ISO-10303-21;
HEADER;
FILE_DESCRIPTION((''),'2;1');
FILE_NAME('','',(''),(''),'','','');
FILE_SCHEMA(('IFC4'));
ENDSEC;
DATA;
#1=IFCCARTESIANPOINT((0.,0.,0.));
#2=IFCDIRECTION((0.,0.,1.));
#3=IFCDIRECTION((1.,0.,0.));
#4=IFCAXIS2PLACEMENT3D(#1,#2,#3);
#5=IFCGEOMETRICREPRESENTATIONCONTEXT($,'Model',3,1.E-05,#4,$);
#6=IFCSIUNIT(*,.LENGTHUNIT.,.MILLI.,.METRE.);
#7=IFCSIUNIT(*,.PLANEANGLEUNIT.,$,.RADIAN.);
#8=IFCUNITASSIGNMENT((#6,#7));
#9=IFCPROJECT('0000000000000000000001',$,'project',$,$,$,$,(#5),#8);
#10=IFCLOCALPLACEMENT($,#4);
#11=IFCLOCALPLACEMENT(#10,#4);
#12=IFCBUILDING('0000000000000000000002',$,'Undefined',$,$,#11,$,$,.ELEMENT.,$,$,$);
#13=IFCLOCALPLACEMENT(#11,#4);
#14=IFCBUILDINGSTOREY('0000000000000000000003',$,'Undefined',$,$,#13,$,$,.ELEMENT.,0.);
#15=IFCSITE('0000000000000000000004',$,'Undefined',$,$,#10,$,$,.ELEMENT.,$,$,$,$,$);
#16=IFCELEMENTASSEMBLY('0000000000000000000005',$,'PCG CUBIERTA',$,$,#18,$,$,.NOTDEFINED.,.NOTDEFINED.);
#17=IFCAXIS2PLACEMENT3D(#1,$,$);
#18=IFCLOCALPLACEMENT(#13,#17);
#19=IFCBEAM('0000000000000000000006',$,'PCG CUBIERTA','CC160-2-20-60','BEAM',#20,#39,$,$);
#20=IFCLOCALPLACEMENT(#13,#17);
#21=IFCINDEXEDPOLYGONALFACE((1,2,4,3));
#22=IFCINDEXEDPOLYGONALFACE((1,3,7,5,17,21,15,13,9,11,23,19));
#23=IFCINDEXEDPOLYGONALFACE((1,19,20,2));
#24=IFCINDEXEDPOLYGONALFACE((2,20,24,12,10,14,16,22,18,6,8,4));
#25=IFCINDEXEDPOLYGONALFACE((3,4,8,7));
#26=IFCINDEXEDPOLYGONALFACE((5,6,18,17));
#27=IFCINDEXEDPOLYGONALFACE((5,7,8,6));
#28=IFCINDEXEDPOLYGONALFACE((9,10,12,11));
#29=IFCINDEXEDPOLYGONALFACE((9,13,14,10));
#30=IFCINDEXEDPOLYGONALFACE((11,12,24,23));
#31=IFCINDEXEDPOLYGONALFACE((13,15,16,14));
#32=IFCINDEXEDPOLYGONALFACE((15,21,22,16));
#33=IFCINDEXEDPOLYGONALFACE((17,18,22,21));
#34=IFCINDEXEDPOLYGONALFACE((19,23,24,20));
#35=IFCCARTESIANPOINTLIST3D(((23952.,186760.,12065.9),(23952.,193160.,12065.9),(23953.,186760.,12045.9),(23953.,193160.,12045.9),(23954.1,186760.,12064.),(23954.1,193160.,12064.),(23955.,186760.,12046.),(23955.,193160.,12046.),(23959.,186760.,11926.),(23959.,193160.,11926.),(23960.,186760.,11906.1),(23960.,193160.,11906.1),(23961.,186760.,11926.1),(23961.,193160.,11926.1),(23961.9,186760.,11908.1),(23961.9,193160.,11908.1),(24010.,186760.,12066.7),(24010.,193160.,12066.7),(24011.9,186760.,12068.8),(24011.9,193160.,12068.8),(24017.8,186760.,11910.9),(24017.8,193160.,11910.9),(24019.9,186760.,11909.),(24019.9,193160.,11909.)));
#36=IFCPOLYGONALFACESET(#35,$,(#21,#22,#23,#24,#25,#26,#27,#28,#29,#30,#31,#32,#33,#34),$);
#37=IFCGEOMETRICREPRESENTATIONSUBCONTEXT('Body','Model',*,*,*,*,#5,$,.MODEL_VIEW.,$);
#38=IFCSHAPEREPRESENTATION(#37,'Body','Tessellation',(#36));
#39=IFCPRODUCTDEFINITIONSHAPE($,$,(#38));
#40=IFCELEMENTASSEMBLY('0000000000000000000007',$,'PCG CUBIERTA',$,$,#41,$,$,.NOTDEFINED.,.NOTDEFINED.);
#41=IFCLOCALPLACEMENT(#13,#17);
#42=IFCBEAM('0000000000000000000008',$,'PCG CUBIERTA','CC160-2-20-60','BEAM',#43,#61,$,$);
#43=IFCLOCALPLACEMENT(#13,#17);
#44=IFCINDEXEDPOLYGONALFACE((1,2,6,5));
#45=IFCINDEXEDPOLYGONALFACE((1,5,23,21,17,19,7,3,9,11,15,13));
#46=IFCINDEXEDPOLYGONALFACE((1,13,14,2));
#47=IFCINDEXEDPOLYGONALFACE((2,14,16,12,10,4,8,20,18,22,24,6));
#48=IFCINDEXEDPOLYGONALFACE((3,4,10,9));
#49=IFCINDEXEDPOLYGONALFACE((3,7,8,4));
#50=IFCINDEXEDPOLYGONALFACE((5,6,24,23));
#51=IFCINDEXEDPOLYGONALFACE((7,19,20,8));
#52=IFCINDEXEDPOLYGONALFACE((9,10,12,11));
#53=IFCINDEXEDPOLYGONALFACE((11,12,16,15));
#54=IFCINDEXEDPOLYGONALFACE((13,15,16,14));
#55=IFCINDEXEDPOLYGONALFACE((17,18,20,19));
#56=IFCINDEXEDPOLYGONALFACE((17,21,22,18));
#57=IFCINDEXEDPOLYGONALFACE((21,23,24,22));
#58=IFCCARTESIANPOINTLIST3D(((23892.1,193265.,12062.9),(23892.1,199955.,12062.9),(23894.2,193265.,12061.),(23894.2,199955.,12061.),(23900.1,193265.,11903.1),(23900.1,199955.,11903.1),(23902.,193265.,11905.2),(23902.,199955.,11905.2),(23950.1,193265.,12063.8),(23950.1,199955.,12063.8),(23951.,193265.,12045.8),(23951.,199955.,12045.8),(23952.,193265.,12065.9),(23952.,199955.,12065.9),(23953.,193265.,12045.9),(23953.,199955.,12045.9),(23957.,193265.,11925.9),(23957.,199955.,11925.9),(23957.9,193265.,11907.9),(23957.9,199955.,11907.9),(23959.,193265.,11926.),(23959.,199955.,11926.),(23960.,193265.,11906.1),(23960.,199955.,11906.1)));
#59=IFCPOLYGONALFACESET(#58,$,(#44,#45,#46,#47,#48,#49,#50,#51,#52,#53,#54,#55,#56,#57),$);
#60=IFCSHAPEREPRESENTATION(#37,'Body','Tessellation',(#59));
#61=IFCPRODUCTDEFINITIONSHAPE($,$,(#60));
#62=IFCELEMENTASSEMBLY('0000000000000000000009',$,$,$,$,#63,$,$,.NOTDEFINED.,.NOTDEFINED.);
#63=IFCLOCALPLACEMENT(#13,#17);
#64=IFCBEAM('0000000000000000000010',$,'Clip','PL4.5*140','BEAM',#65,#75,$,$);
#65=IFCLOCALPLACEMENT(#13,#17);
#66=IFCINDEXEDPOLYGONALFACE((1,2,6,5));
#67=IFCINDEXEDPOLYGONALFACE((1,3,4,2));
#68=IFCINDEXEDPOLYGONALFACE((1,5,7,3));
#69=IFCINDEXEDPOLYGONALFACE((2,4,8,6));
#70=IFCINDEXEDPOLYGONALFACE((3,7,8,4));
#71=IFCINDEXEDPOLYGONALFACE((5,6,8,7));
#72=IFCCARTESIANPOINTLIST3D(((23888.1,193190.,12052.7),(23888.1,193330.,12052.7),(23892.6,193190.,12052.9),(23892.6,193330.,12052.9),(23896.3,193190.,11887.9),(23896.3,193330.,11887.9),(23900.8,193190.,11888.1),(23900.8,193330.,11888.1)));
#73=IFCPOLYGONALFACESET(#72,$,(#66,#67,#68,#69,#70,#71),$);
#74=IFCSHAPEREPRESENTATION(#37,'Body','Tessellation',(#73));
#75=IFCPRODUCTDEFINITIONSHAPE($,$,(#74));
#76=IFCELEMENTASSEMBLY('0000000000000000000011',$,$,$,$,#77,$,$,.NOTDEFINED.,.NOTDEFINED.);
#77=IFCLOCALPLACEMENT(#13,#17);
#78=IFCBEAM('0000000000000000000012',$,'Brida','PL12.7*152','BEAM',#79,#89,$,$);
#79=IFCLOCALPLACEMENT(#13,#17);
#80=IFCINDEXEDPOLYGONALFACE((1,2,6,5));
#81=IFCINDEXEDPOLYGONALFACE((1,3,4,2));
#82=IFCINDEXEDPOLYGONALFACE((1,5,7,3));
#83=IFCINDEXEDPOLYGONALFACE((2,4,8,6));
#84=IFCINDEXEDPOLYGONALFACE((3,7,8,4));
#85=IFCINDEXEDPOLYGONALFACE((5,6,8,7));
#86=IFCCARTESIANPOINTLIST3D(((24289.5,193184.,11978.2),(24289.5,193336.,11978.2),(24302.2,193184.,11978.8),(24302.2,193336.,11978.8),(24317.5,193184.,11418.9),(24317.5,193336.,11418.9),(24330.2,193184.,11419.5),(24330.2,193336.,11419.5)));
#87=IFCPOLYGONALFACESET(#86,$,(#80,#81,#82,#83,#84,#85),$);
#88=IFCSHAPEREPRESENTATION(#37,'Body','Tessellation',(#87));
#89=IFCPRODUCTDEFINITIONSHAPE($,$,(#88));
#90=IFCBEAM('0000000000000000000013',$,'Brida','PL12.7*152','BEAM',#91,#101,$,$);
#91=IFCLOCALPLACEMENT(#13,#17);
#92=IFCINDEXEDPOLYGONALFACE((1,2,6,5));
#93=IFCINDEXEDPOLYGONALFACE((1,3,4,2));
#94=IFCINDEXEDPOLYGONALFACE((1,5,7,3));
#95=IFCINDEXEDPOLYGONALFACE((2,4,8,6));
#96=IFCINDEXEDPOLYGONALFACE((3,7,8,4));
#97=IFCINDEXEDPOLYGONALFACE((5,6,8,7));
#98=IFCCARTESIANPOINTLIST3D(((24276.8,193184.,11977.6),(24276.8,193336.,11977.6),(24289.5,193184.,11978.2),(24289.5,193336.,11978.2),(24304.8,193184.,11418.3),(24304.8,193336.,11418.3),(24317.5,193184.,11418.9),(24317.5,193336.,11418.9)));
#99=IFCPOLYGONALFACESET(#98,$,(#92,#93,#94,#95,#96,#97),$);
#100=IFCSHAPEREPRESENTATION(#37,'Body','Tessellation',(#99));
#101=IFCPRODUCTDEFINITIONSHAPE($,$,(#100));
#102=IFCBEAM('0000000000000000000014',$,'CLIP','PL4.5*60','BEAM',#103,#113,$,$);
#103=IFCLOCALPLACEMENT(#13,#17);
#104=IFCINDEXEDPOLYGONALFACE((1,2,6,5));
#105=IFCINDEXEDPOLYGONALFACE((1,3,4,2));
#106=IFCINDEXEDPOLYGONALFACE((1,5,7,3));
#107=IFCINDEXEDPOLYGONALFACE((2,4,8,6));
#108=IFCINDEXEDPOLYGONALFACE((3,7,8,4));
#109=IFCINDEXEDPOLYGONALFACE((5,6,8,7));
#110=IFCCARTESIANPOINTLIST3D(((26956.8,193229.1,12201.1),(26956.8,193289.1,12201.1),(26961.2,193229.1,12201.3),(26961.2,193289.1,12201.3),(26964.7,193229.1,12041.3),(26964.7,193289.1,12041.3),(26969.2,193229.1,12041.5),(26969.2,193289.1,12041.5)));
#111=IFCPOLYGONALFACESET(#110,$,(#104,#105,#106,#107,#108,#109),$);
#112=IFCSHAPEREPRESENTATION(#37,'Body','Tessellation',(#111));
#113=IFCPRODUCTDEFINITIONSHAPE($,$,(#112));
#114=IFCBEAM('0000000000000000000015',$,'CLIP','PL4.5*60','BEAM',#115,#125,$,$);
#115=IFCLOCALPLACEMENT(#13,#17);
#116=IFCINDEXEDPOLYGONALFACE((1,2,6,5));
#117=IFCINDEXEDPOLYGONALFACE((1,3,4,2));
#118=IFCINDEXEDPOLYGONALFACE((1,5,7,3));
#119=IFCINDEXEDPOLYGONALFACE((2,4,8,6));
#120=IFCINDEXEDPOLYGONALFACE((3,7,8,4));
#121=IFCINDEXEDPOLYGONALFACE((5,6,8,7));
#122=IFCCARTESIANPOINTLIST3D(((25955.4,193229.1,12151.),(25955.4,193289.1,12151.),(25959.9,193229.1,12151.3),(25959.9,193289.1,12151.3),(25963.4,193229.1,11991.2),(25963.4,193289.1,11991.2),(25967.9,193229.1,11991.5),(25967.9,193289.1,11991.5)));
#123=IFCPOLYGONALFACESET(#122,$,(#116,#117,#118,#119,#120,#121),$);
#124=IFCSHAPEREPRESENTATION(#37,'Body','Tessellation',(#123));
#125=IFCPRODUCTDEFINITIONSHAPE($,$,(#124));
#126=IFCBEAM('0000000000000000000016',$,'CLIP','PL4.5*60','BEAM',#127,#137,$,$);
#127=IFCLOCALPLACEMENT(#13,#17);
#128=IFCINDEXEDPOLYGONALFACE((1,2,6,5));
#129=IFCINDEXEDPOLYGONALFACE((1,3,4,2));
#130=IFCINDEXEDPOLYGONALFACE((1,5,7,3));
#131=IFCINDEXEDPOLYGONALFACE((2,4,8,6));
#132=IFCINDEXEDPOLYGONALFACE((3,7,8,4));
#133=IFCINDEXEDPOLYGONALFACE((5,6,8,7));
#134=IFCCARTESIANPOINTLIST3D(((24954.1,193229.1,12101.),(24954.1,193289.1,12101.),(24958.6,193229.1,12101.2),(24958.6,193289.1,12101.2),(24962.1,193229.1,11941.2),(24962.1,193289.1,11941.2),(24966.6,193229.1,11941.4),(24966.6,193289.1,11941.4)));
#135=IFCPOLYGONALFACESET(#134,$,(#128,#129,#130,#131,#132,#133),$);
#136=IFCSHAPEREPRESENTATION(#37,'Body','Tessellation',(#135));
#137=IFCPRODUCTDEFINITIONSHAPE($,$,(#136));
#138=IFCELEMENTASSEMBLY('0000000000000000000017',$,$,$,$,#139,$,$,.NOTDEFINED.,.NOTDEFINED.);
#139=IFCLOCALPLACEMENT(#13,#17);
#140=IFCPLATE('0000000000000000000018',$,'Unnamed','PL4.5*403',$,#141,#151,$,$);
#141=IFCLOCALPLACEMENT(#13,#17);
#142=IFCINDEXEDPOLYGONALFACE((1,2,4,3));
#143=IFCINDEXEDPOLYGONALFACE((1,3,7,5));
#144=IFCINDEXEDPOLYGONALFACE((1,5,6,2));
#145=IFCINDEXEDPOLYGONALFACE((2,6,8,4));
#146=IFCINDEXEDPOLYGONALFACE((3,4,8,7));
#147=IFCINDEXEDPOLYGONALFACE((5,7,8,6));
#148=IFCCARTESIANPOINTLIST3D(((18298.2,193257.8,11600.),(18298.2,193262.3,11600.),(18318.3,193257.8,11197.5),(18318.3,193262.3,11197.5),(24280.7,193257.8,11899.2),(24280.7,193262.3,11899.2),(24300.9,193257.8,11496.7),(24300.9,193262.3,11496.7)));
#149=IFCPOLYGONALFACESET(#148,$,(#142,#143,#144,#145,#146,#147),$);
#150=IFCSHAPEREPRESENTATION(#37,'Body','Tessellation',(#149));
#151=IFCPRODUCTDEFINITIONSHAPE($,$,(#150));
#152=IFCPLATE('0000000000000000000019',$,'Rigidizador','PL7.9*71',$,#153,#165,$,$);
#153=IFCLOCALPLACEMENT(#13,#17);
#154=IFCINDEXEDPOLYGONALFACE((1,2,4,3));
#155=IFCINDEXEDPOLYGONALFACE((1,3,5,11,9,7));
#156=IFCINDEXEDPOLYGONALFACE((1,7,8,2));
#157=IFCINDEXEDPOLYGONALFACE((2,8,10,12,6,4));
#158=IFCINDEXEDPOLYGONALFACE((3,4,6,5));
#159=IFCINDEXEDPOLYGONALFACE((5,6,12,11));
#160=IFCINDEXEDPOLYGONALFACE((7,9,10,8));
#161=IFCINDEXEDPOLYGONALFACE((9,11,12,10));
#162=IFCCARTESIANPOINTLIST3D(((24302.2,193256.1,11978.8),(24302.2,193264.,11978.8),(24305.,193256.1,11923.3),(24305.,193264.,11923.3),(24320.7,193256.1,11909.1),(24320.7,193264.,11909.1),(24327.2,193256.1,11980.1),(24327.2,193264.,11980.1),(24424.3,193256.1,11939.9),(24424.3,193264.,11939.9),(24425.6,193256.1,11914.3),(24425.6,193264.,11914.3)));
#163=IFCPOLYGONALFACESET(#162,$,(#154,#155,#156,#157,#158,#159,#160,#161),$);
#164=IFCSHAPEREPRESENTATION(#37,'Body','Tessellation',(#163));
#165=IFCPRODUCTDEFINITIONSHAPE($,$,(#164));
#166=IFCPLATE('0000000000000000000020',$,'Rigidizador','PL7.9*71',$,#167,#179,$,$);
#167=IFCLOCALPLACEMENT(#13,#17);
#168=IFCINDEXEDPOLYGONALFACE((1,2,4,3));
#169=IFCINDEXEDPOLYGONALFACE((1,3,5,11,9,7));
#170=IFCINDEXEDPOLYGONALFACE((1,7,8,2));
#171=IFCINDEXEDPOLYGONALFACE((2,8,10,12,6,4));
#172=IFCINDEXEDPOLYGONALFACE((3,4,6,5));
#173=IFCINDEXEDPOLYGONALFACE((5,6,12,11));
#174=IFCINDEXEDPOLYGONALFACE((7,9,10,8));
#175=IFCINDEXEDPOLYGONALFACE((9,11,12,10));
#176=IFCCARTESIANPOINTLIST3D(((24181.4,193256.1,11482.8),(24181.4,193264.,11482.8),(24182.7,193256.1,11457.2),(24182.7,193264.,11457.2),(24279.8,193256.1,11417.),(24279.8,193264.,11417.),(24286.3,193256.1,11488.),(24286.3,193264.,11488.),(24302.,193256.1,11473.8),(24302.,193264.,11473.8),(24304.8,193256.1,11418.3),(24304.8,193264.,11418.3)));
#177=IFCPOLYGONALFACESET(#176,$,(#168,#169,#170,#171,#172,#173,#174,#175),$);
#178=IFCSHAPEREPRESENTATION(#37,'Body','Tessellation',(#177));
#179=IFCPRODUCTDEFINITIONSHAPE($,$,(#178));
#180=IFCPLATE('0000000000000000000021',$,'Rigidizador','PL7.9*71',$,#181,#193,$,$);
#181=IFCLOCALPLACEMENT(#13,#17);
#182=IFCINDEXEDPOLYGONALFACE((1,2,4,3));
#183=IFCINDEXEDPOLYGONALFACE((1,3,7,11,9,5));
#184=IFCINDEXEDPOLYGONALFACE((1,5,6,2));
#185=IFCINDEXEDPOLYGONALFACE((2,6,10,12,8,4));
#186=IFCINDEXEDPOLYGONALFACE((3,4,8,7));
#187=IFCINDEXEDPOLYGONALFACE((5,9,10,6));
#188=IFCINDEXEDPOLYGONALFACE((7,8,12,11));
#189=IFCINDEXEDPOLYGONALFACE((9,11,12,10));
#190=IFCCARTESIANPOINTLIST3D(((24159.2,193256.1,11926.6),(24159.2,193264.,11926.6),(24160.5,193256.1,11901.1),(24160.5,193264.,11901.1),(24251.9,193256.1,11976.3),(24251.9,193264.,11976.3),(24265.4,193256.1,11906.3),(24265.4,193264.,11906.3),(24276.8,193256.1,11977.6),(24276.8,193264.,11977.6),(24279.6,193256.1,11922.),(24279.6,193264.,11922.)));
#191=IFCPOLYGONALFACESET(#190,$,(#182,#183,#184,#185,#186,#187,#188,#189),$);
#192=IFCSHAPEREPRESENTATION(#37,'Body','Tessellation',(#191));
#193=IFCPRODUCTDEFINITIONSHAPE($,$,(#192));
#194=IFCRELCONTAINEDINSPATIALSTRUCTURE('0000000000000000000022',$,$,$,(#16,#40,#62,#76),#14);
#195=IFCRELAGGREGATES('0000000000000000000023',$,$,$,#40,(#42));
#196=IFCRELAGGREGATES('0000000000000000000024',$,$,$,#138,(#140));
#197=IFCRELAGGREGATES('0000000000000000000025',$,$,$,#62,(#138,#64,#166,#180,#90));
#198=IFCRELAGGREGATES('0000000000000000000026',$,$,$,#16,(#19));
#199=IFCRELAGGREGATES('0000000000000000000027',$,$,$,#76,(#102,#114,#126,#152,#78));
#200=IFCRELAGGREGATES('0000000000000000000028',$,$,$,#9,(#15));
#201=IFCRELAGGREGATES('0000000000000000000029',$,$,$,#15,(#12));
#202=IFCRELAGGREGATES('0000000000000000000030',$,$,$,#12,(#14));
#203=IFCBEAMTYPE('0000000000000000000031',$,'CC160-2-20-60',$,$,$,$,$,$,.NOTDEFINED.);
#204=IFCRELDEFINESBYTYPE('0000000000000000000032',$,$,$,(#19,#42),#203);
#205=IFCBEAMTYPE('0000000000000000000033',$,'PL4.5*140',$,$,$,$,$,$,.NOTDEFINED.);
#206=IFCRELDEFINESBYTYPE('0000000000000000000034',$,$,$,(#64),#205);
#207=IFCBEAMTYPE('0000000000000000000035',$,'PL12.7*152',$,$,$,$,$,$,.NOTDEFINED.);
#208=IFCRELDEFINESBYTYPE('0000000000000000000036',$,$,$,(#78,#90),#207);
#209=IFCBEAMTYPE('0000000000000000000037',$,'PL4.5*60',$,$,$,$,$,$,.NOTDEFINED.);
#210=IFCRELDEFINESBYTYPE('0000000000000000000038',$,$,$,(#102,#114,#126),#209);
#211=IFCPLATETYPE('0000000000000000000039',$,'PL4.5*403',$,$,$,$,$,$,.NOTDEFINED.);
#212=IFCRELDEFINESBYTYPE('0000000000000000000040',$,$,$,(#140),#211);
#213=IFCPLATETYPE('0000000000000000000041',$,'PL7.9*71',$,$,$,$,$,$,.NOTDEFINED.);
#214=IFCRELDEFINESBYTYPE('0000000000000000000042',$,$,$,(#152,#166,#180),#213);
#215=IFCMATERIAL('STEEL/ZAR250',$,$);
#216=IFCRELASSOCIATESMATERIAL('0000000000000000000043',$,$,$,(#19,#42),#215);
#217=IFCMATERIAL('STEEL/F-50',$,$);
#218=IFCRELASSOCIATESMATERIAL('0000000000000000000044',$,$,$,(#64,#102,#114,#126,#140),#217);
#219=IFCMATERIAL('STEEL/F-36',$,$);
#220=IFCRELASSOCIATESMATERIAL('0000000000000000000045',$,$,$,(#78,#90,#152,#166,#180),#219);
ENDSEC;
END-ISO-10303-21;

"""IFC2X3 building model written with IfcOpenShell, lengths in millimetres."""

from ifc_helpers import new_model, si_unit, frame, origin_with_axes, origin_2d_with_axis, place, context, subcontext, project, spatial, polyline, rectangle, c_section, outline, extrude, material, type_object, element, aggregate, save


model = new_model("IFC2X3")

# Units and contexts
model_context = context("Model", 3, precision=1e-05, world=origin_with_axes())
body_context = subcontext(model_context, "Body", "Model", "MODEL_VIEW")
ifc_project = project(units=[si_unit("LENGTHUNIT", "METRE", prefix="MILLI"), si_unit("PLANEANGLEUNIT", "RADIAN")], contexts=[model_context])

# Site, building, storey
site_placement = place(None, origin_with_axes())
site = spatial("IfcSite", under=ifc_project, at=site_placement, Name="Undefined", CompositionType="ELEMENT")
building_placement = place(site_placement, origin_with_axes())
building = spatial("IfcBuilding", under=site, at=building_placement, Name="Undefined", CompositionType="ELEMENT")
storey_placement = place(building_placement, origin_with_axes())
storey = spatial("IfcBuildingStorey", under=building, at=storey_placement, Name="Undefined", CompositionType="ELEMENT", Elevation=0.0)

# Element assemblies, beams
assembly_1_placement = place(storey_placement, origin_with_axes())
assembly_1 = element("IfcElementAssembly", 1, at=assembly_1_placement, inside=storey, Name="PCG CUBIERTA", AssemblyPlace="NOTDEFINED", PredefinedType="NOTDEFINED")
ifc_material_1 = material(Name="STEEL/ZAR250")
beam_type_1 = type_object("IfcBeamType", Name="CC160-2-20-60", PredefinedType="NOTDEFINED")
beam_1_placement = place(assembly_1_placement, frame((23986.0, 193160.0, 11987.4), z_axis=(-0.049943, 0.0, 0.998752), x_axis=(0.0, -1.0, 0.0)))
beam_1 = element("IfcBeam", 2, at=beam_1_placement, type_object=beam_type_1, material=ifc_material_1, Name="PCG CUBIERTA", Description="CC160-2-20-60", ObjectType="BEAM", context=body_context, shape_type="SweptSolid", body=[
    extrude(c_section(Depth=160.0, Width=60.0, WallThickness=2.0, Girth=20.0, at=origin_2d_with_axis()), frame((6400.0, 0.0, 0.0), z_axis=(-1.0, 0.0, 0.0), x_axis=(0.0, -1.0, 0.0)), (0.0, 0.0, 1.0), 6400.0),
])
assembly_2_placement = place(storey_placement, origin_with_axes())
assembly_2 = element("IfcElementAssembly", 3, at=assembly_2_placement, inside=storey, Name="PCG CUBIERTA", AssemblyPlace="NOTDEFINED", PredefinedType="NOTDEFINED")
beam_2_placement = place(assembly_2_placement, frame((23926.0, 193265.0, 11984.5), z_axis=(-0.049943, 0.0, 0.998752), x_axis=(0.0, 1.0, 0.0)))
beam_2 = element("IfcBeam", 4, at=beam_2_placement, type_object=beam_type_1, material=ifc_material_1, Name="PCG CUBIERTA", Description="CC160-2-20-60", ObjectType="BEAM", context=body_context, shape_type="SweptSolid", body=[
    extrude(c_section(Depth=160.0, Width=60.0, WallThickness=2.0, Girth=20.0, at=origin_2d_with_axis()), frame((6690.0, 0.0, 0.0), z_axis=(-1.0, 0.0, 0.0), x_axis=(0.0, -1.0, 0.0)), (0.0, 0.0, 1.0), 6690.0),
])
aggregate(assembly_2, [beam_2])
assembly_3_placement = place(storey_placement, origin_with_axes())
assembly_3 = element("IfcElementAssembly", 5, at=assembly_3_placement, inside=storey, AssemblyPlace="NOTDEFINED", PredefinedType="NOTDEFINED")
ifc_material_2 = material(Name="STEEL/F-50")
beam_type_2 = type_object("IfcBeamType", Name="PL4.5*140", PredefinedType="NOTDEFINED")
beam_3_placement = place(assembly_3_placement, frame((23890.3, 193260.0, 12052.8), z_axis=(0.0, -1.0, 0.0), x_axis=(0.049943, 0.0, -0.998752)))
beam_3 = element("IfcBeam", 6, at=beam_3_placement, type_object=beam_type_2, material=ifc_material_2, Name="Clip", Description="PL4.5*140", ObjectType="BEAM", context=body_context, shape_type="SweptSolid", body=[
    extrude(rectangle(XDim=4.5, YDim=140.0, at=origin_2d_with_axis()), frame((165.0, 0.0, 0.0), z_axis=(-1.0, 0.0, 0.0), x_axis=(0.0, -1.0, 0.0)), (0.0, 0.0, 1.0), 165.0),
])
assembly_4_placement = place(storey_placement, origin_with_axes())
assembly_4 = element("IfcElementAssembly", 7, at=assembly_4_placement, inside=storey, AssemblyPlace="NOTDEFINED", PredefinedType="NOTDEFINED")
ifc_material_3 = material(Name="STEEL/F-36")
beam_type_3 = type_object("IfcBeamType", Name="PL12.7*152", PredefinedType="NOTDEFINED")
beam_4_placement = place(assembly_4_placement, frame((24295.8, 193260.0, 11978.5), z_axis=(0.0, 1.0, 0.0), x_axis=(0.049943, 0.0, -0.998752)))
beam_4 = element("IfcBeam", 8, at=beam_4_placement, type_object=beam_type_3, material=ifc_material_3, Name="Brida", Description="PL12.7*152", ObjectType="BEAM", context=body_context, shape_type="SweptSolid", body=[
    extrude(rectangle(XDim=12.7, YDim=152.0, at=origin_2d_with_axis()), frame((560.0, 0.0, 0.0), z_axis=(-1.0, 0.0, 0.0), x_axis=(0.0, -1.0, 0.0)), (0.0, 0.0, 1.0), 560.0),
])

# Beams
beam_5_placement = place(assembly_3_placement, frame((24283.2, 193260.0, 11977.9), z_axis=(0.0, 1.0, 0.0), x_axis=(0.049943, 0.0, -0.998752)))
beam_5 = element("IfcBeam", 9, at=beam_5_placement, type_object=beam_type_3, material=ifc_material_3, Name="Brida", Description="PL12.7*152", ObjectType="BEAM", context=body_context, shape_type="SweptSolid", body=[
    extrude(rectangle(XDim=12.7, YDim=152.0, at=origin_2d_with_axis()), frame((560.0, 0.0, 0.0), z_axis=(-1.0, 0.0, 0.0), x_axis=(0.0, -1.0, 0.0)), (0.0, 0.0, 1.0), 560.0),
])
beam_type_4 = type_object("IfcBeamType", Name="PL4.5*60", PredefinedType="NOTDEFINED")
beam_6_placement = place(assembly_4_placement, frame((26959.0, 193259.1, 12201.2), z_axis=(0.0, 1.0, 0.0), x_axis=(0.049943, 0.0, -0.998752)))
beam_6 = element("IfcBeam", 10, at=beam_6_placement, type_object=beam_type_4, material=ifc_material_2, Name="CLIP", Description="PL4.5*60", ObjectType="BEAM", context=body_context, shape_type="SweptSolid", body=[
    extrude(rectangle(XDim=4.5, YDim=60.0, at=origin_2d_with_axis()), frame((160.0, 0.0, 0.0), z_axis=(-1.0, 0.0, 0.0), x_axis=(0.0, -1.0, 0.0)), (0.0, 0.0, 1.0), 160.0),
])
beam_7_placement = place(assembly_4_placement, frame((25957.7, 193259.1, 12151.1), z_axis=(0.0, 1.0, 0.0), x_axis=(0.049943, 0.0, -0.998752)))
beam_7 = element("IfcBeam", 11, at=beam_7_placement, type_object=beam_type_4, material=ifc_material_2, Name="CLIP", Description="PL4.5*60", ObjectType="BEAM", context=body_context, shape_type="SweptSolid", body=[
    extrude(rectangle(XDim=4.5, YDim=60.0, at=origin_2d_with_axis()), frame((160.0, 0.0, 0.0), z_axis=(-1.0, 0.0, 0.0), x_axis=(0.0, -1.0, 0.0)), (0.0, 0.0, 1.0), 160.0),
])
beam_8_placement = place(assembly_4_placement, frame((24956.3, 193259.1, 12101.1), z_axis=(0.0, 1.0, 0.0), x_axis=(0.049943, 0.0, -0.998752)))
beam_8 = element("IfcBeam", 12, at=beam_8_placement, type_object=beam_type_4, material=ifc_material_2, Name="CLIP", Description="PL4.5*60", ObjectType="BEAM", context=body_context, shape_type="SweptSolid", body=[
    extrude(rectangle(XDim=4.5, YDim=60.0, at=origin_2d_with_axis()), frame((160.0, 0.0, 0.0), z_axis=(-1.0, 0.0, 0.0), x_axis=(0.0, -1.0, 0.0)), (0.0, 0.0, 1.0), 160.0),
])

# Element assembly, plate
assembly_5_placement = place(assembly_3_placement, origin_with_axes())
assembly_5 = element("IfcElementAssembly", 13, at=assembly_5_placement, AssemblyPlace="NOTDEFINED", PredefinedType="NOTDEFINED")
plate_type_1 = type_object("IfcPlateType", Name="PL4.5*403", PredefinedType="NOTDEFINED")
plate_1_placement = place(assembly_5_placement, frame((24280.7, 193260.0, 11899.2), z_axis=(0.0, -1.0, 0.0), x_axis=(-0.998752, 0.0, -0.049943)))
plate_1 = element("IfcPlate", 14, at=plate_1_placement, type_object=plate_type_1, material=ifc_material_2, Name="Unnamed", Description="PL4.5*403", context=body_context, shape_type="SweptSolid", body=[
    extrude(outline(polyline([(0.0, 0.0), (5990.0, 0.0), (5990.0, 403.0), (0.0, 403.0), (0.0, 0.0)])), frame((0.0, 0.0, -2.2), z_axis=(0.0, 0.0, 1.0), x_axis=(1.0, 0.0, 0.0)), (0.0, 0.0, 1.0), 4.5),
])
aggregate(assembly_5, [plate_1])

# Plates
plate_type_2 = type_object("IfcPlateType", Name="PL7.9*71", PredefinedType="NOTDEFINED")
plate_2_placement = place(assembly_4_placement, frame((24302.2, 193260.0, 11978.8), z_axis=(0.0, -1.0, 0.0), x_axis=(0.049943, 0.0, -0.998752)))
plate_2 = element("IfcPlate", 15, at=plate_2_placement, type_object=plate_type_2, material=ifc_material_3, Name="Rigidizador", Description="PL7.9*71", context=body_context, shape_type="SweptSolid", body=[
    extrude(outline(polyline([(0.0, 0.0), (55.6, 0.0), (70.6, 15.0), (70.6, 120.0), (45.0, 120.0), (0.0, 25.0), (0.0, 0.0)])), frame((0.0, 0.0, -4.0), z_axis=(0.0, 0.0, 1.0), x_axis=(1.0, 0.0, 0.0)), (0.0, 0.0, 1.0), 7.9),
])
plate_3_placement = place(assembly_3_placement, frame((24304.8, 193260.0, 11418.3), z_axis=(0.0, -1.0, 0.0), x_axis=(-0.049943, 0.0, 0.998752)))
plate_3 = element("IfcPlate", 16, at=plate_3_placement, type_object=plate_type_2, material=ifc_material_3, Name="Rigidizador", Description="PL7.9*71", context=body_context, shape_type="SweptSolid", body=[
    extrude(outline(polyline([(0.0, 0.0), (55.6, 0.0), (70.6, 15.0), (70.6, 120.0), (45.0, 120.0), (0.0, 25.0), (0.0, 0.0)])), frame((0.0, 0.0, -4.0), z_axis=(0.0, 0.0, 1.0), x_axis=(1.0, 0.0, 0.0)), (0.0, 0.0, 1.0), 7.9),
])
plate_4_placement = place(assembly_3_placement, frame((24276.8, 193260.0, 11977.6), z_axis=(0.0, 1.0, 0.0), x_axis=(0.049943, 0.0, -0.998752)))
plate_4 = element("IfcPlate", 17, at=plate_4_placement, type_object=plate_type_2, material=ifc_material_3, Name="Rigidizador", Description="PL7.9*71", context=body_context, shape_type="SweptSolid", body=[
    extrude(outline(polyline([(0.0, 0.0), (55.6, 0.0), (70.6, 15.0), (70.6, 120.0), (45.0, 120.0), (0.0, 25.0), (0.0, 0.0)])), frame((0.0, 0.0, -4.0), z_axis=(0.0, 0.0, 1.0), x_axis=(1.0, 0.0, 0.0)), (0.0, 0.0, 1.0), 7.9),
])
aggregate(assembly_3, [assembly_5, beam_3, plate_3, plate_4, beam_5])

aggregate(assembly_1, [beam_1])

aggregate(assembly_4, [beam_6, beam_7, beam_8, plate_2, beam_4])

save(model, "model.ifc")
